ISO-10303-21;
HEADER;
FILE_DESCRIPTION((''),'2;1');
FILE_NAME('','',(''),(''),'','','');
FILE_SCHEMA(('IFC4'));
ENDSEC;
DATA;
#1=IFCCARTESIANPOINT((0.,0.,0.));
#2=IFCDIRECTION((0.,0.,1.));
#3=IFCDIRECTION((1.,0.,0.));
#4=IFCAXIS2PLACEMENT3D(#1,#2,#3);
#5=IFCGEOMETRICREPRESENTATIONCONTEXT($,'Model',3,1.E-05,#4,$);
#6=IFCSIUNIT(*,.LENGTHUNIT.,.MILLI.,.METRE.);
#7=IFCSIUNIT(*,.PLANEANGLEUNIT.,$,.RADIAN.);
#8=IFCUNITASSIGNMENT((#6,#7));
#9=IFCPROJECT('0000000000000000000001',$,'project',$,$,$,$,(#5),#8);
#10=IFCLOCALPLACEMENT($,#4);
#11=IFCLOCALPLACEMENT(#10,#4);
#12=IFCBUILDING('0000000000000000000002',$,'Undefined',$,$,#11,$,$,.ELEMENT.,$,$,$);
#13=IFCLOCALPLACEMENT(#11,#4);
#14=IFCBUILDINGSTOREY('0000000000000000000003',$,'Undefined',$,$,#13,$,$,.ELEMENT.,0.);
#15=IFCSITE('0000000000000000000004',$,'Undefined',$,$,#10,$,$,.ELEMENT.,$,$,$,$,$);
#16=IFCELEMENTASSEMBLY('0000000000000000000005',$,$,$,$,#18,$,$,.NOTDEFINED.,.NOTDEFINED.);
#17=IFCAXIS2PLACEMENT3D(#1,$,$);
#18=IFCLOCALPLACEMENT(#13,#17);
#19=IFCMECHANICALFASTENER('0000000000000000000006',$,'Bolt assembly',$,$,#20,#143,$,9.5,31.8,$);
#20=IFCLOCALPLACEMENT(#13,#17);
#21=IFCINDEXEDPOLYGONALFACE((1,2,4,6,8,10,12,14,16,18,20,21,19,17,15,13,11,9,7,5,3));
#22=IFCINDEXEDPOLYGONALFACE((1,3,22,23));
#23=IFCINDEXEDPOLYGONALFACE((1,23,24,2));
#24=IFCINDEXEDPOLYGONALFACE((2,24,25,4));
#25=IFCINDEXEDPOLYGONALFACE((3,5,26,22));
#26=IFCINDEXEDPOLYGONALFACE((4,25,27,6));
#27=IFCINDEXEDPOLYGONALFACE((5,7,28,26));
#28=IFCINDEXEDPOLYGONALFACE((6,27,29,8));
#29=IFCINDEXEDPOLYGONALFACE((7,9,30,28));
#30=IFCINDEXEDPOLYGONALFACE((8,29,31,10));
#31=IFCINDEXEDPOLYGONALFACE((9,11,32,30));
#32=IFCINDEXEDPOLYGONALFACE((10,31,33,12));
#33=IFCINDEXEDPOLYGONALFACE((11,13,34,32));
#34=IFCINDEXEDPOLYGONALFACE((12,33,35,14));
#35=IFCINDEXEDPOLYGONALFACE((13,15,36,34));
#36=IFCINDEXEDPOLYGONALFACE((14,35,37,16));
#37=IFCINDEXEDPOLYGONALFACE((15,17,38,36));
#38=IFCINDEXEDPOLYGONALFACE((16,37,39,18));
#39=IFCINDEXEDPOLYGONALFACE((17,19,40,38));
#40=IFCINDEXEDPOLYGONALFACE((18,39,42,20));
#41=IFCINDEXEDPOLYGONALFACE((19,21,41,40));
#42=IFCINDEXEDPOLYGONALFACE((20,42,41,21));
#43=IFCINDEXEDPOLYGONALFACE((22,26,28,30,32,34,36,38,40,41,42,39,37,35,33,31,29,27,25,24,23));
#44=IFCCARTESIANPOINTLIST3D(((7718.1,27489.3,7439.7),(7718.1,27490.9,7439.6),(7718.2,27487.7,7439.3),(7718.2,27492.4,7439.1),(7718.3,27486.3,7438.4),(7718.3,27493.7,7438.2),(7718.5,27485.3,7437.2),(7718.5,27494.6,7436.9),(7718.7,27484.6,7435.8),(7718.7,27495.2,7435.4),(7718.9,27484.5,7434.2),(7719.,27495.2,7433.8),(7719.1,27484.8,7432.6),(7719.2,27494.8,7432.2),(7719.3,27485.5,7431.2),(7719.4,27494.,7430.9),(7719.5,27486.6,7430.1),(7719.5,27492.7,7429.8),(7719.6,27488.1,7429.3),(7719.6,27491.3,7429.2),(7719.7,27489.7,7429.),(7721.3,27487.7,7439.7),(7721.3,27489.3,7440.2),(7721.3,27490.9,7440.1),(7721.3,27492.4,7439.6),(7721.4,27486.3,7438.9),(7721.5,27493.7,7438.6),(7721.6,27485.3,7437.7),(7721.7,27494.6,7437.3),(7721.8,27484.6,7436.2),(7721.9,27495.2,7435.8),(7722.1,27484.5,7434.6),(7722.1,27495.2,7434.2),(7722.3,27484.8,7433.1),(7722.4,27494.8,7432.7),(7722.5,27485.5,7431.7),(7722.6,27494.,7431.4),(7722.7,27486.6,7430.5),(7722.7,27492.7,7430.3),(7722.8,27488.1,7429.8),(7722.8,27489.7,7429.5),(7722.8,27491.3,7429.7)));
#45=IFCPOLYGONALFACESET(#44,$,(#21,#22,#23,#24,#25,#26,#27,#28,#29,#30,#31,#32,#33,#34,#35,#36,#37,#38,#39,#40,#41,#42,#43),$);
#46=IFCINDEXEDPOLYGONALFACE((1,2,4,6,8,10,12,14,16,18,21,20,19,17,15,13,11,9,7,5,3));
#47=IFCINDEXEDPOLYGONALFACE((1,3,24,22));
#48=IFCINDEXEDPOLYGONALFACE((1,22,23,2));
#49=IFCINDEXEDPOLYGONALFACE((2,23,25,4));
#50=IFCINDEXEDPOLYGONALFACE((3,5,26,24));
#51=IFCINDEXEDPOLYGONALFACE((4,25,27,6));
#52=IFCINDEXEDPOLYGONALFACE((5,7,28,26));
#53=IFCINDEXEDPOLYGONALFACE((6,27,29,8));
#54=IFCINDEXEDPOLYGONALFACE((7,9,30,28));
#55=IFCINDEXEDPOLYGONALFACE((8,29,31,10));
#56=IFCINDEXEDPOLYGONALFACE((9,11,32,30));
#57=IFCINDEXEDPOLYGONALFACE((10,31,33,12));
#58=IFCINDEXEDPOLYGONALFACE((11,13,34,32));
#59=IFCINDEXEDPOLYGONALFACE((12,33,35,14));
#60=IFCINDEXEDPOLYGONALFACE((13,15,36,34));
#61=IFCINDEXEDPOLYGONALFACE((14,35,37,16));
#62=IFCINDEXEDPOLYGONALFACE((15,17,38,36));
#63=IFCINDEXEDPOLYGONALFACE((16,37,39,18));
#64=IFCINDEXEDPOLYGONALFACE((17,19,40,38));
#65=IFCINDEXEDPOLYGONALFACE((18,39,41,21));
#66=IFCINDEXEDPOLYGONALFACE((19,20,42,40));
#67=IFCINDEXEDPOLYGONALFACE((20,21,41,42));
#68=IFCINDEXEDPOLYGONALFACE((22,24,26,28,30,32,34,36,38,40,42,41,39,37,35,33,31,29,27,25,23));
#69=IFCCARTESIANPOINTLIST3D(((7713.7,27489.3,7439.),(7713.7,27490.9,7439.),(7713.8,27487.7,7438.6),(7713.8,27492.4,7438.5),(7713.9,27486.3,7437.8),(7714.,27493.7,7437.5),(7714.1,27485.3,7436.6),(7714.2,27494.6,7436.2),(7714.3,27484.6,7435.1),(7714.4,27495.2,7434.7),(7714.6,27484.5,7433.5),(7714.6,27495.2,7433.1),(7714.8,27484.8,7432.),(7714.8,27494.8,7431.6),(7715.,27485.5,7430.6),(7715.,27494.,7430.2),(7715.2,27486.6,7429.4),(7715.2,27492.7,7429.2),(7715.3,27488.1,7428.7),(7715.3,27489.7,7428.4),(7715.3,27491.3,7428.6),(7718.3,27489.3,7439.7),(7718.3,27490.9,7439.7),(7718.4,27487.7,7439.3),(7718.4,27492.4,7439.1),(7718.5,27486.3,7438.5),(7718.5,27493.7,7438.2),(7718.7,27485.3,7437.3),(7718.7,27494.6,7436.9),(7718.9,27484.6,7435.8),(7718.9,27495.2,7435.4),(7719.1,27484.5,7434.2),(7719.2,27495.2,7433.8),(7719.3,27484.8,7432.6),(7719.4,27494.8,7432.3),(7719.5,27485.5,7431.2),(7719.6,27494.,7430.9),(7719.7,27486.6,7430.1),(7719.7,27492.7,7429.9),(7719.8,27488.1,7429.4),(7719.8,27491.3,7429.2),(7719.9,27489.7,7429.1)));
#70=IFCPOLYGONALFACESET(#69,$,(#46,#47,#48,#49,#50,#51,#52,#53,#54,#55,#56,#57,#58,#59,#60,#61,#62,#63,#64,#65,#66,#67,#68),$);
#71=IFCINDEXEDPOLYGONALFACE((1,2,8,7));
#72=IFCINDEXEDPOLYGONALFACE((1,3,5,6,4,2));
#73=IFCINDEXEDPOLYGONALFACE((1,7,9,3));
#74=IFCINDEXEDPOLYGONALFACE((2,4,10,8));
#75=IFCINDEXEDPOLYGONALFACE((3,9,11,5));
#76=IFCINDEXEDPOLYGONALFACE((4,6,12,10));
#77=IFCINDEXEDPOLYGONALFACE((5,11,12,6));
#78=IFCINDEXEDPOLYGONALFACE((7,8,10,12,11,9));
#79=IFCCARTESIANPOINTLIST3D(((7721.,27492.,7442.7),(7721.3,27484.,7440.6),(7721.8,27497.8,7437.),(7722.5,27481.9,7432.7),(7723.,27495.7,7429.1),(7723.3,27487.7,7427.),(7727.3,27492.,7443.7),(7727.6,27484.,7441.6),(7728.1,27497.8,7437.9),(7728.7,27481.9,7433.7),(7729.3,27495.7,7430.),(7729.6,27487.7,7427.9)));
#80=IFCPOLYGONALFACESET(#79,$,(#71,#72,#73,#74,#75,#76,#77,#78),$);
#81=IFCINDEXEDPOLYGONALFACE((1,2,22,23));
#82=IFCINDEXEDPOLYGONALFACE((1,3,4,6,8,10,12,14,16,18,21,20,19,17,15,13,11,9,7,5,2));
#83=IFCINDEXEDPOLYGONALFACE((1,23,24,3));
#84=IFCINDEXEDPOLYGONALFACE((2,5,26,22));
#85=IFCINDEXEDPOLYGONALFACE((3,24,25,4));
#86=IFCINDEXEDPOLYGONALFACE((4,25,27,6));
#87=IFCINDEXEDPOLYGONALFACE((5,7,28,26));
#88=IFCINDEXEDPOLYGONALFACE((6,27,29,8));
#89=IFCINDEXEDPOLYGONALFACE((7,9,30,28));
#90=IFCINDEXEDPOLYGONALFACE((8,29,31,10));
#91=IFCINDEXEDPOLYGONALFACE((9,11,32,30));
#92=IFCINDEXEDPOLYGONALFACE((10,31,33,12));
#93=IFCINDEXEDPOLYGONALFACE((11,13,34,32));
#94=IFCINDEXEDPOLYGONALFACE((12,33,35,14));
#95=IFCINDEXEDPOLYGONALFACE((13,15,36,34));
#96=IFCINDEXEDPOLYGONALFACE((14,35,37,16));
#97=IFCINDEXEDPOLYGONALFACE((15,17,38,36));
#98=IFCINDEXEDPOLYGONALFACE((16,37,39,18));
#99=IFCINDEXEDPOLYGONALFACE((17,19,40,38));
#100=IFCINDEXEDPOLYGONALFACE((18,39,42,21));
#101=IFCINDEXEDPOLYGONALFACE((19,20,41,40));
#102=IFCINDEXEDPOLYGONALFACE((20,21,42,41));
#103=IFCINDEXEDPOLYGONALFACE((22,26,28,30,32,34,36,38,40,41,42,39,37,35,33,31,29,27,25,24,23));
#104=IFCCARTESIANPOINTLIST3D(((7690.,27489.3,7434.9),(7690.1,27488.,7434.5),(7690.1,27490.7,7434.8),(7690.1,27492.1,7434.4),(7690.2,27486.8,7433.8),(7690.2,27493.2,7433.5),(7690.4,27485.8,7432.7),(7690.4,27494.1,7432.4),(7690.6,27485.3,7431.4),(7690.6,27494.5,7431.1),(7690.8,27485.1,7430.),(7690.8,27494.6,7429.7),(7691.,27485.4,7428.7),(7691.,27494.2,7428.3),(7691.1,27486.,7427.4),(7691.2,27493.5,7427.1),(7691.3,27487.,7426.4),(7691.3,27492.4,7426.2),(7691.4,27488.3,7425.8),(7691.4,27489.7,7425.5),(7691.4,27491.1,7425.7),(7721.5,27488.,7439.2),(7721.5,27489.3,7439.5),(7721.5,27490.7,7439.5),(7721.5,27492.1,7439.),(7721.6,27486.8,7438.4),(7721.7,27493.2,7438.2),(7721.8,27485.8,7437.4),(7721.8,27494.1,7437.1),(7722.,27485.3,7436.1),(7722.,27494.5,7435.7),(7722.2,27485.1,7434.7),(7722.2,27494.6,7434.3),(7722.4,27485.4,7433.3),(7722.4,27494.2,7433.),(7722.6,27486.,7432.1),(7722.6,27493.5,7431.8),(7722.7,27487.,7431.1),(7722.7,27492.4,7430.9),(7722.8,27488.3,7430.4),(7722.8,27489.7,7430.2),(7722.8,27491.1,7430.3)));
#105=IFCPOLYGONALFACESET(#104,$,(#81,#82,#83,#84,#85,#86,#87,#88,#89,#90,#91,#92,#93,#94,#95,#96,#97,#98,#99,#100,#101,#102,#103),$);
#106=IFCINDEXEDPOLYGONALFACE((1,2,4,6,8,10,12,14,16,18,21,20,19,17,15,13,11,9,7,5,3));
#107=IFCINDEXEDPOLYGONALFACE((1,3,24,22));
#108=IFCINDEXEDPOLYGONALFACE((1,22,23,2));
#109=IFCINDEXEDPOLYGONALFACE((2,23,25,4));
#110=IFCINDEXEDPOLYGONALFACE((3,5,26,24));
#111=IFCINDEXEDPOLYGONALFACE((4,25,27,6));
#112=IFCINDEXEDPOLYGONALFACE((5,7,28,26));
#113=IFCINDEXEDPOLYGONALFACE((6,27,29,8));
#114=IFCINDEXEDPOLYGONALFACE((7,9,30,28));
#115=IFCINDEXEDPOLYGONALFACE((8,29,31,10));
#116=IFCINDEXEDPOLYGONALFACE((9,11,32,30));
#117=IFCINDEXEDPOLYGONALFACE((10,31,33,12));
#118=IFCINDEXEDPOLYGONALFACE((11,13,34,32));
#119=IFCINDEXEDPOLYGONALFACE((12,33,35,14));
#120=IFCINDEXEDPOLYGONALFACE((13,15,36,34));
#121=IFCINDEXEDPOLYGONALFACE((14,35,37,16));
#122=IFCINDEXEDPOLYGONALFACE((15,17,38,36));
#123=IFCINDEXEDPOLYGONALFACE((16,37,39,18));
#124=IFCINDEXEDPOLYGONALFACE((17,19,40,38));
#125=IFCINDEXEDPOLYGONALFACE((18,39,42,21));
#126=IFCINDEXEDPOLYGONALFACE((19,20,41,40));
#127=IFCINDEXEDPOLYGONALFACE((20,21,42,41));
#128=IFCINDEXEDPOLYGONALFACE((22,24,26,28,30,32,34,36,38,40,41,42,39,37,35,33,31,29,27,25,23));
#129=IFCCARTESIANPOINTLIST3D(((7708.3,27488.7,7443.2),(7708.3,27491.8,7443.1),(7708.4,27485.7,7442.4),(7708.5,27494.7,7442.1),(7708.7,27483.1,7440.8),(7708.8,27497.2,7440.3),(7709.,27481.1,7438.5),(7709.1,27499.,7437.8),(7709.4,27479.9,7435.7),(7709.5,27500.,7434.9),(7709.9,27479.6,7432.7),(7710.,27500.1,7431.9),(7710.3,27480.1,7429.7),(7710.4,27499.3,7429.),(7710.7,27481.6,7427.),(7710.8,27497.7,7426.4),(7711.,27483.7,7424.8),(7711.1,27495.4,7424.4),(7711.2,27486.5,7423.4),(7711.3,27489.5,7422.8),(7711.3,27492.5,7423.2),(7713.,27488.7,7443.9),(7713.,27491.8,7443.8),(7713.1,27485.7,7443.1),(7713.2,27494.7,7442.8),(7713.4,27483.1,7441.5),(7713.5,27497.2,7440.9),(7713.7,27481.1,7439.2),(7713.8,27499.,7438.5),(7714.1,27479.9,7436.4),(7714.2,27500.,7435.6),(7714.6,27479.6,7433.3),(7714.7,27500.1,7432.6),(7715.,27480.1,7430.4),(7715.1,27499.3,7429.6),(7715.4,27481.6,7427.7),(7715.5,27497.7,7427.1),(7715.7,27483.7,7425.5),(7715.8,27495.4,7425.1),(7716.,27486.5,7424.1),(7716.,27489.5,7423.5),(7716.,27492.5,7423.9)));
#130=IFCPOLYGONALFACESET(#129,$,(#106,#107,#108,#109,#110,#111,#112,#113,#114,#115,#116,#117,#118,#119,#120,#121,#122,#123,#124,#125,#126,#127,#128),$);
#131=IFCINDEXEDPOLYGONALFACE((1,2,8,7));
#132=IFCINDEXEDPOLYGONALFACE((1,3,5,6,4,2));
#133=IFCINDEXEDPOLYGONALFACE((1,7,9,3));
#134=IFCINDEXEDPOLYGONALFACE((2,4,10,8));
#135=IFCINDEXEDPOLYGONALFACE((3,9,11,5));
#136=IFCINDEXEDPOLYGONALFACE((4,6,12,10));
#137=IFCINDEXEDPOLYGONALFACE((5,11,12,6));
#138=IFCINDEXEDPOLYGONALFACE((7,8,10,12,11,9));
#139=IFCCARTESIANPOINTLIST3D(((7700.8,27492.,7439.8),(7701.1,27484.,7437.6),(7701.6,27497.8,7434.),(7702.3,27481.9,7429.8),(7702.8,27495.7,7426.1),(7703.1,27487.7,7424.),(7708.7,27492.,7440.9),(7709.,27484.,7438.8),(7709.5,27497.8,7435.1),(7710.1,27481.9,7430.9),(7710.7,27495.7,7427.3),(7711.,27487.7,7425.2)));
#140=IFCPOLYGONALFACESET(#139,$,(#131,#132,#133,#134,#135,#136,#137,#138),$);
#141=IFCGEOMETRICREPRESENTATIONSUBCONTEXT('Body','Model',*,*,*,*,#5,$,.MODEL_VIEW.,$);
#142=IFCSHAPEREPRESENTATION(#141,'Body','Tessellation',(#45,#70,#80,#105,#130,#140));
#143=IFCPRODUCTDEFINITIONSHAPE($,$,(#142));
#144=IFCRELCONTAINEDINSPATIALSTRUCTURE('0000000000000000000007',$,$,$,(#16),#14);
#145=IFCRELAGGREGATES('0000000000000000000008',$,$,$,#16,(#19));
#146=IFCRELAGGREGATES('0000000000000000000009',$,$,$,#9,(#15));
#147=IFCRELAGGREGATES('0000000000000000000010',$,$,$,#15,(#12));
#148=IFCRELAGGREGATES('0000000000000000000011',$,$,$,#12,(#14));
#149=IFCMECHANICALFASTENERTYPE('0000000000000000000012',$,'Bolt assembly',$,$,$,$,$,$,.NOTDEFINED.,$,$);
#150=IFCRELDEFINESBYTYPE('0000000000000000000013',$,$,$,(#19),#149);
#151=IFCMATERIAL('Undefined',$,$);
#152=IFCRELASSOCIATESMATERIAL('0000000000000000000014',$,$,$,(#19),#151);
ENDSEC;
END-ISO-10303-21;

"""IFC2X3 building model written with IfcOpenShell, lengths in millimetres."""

from ifc_helpers import new_model, si_unit, frame, origin_with_axes, origin_2d_with_axis, place, context, subcontext, project, spatial, polyline, circle, outline, extrude, source, transform, mapped, material, type_object, element, aggregate, save


model = new_model("IFC2X3")

# Units and contexts
model_context = context("Model", 3, precision=1e-05, world=origin_with_axes())
body_context = subcontext(model_context, "Body", "Model", "MODEL_VIEW")
ifc_project = project(units=[si_unit("LENGTHUNIT", "METRE", prefix="MILLI"), si_unit("PLANEANGLEUNIT", "RADIAN")], contexts=[model_context])

# Site, building, storey
site_placement = place(None, origin_with_axes())
site = spatial("IfcSite", under=ifc_project, at=site_placement, Name="Undefined", CompositionType="ELEMENT")
building_placement = place(site_placement, origin_with_axes())
building = spatial("IfcBuilding", under=site, at=building_placement, Name="Undefined", CompositionType="ELEMENT")
storey_placement = place(building_placement, origin_with_axes())
storey = spatial("IfcBuildingStorey", under=building, at=storey_placement, Name="Undefined", CompositionType="ELEMENT", Elevation=0.0)

# Element assembly
assembly_1_placement = place(storey_placement, origin_with_axes())
assembly_1 = element("IfcElementAssembly", 1, at=assembly_1_placement, inside=storey, AssemblyPlace="NOTDEFINED", PredefinedType="NOTDEFINED")

# Shared definitions
ifc_material_1 = material(Name="Undefined")
mechanical_fastener_type = type_object("IfcMechanicalFastenerType", Name="Bolt assembly")

# Mechanical fastener
shared_shape_1 = source(origin_with_axes(), body_context, "Body", "SweptSolid", [
    extrude(circle(Radius=5.4, at=origin_2d_with_axis()), frame((0.0, -3.1, 0.0), z_axis=(0.0, 1.0, 0.0), x_axis=(1.0, 0.0, 0.0)), (0.0, 0.0, 1.0), 3.2),
    extrude(circle(Radius=5.4, at=origin_2d_with_axis()), frame((0.0, -0.1, 0.0), z_axis=(0.0, 1.0, 0.0), x_axis=(1.0, 0.0, 0.0)), (0.0, 0.0, 1.0), 4.6),
    extrude(outline(polyline([(7.1, -4.1), (7.1, 4.1), (0.0, 8.2), (-7.1, 4.1), (-7.1, -4.1), (0.0, -8.2), (7.1, -4.1)])), frame((0.0, -9.6, 0.0), z_axis=(0.0, 1.0, 0.0), x_axis=(1.0, 0.0, 0.0)), (0.0, 0.0, 1.0), 6.3),
    extrude(circle(Radius=4.8, at=origin_2d_with_axis()), frame((0.0, -3.2, 0.0), z_axis=(0.0, 1.0, 0.0), x_axis=(1.0, 0.0, 0.0)), (0.0, 0.0, 1.0), 31.8),
    extrude(circle(Radius=10.3, at=origin_2d_with_axis()), frame((0.0, 4.5, 0.0), z_axis=(0.0, 1.0, 0.0), x_axis=(1.0, 0.0, 0.0)), (0.0, 0.0, 1.0), 4.8),
    extrude(outline(polyline([(7.1, -4.1), (7.1, 4.1), (0.0, 8.2), (-7.1, 4.1), (-7.1, -4.1), (0.0, -8.2), (7.1, -4.1)])), frame((0.0, 9.3, 0.0), z_axis=(0.0, 1.0, 0.0), x_axis=(1.0, 0.0, 0.0)), (0.0, 0.0, 1.0), 7.9),
])
mechanical_fastener_1_placement = place(assembly_1_placement, frame((7719.0, 27489.9, 7434.4), z_axis=(-0.103381, -0.707107, 0.699509), x_axis=(-0.103381, 0.707107, 0.699509)))
mechanical_fastener_1 = element("IfcMechanicalFastener", 2, at=mechanical_fastener_1_placement, type_object=mechanical_fastener_type, material=ifc_material_1, Name="Bolt assembly", NominalDiameter=9.5, NominalLength=31.8, context=body_context, shape_type="MappedRepresentation", body=[
    mapped(shared_shape_1, transform((0.0, 0.0, 0.0))),
])
aggregate(assembly_1, [mechanical_fastener_1])

save(model, "model.ifc")
